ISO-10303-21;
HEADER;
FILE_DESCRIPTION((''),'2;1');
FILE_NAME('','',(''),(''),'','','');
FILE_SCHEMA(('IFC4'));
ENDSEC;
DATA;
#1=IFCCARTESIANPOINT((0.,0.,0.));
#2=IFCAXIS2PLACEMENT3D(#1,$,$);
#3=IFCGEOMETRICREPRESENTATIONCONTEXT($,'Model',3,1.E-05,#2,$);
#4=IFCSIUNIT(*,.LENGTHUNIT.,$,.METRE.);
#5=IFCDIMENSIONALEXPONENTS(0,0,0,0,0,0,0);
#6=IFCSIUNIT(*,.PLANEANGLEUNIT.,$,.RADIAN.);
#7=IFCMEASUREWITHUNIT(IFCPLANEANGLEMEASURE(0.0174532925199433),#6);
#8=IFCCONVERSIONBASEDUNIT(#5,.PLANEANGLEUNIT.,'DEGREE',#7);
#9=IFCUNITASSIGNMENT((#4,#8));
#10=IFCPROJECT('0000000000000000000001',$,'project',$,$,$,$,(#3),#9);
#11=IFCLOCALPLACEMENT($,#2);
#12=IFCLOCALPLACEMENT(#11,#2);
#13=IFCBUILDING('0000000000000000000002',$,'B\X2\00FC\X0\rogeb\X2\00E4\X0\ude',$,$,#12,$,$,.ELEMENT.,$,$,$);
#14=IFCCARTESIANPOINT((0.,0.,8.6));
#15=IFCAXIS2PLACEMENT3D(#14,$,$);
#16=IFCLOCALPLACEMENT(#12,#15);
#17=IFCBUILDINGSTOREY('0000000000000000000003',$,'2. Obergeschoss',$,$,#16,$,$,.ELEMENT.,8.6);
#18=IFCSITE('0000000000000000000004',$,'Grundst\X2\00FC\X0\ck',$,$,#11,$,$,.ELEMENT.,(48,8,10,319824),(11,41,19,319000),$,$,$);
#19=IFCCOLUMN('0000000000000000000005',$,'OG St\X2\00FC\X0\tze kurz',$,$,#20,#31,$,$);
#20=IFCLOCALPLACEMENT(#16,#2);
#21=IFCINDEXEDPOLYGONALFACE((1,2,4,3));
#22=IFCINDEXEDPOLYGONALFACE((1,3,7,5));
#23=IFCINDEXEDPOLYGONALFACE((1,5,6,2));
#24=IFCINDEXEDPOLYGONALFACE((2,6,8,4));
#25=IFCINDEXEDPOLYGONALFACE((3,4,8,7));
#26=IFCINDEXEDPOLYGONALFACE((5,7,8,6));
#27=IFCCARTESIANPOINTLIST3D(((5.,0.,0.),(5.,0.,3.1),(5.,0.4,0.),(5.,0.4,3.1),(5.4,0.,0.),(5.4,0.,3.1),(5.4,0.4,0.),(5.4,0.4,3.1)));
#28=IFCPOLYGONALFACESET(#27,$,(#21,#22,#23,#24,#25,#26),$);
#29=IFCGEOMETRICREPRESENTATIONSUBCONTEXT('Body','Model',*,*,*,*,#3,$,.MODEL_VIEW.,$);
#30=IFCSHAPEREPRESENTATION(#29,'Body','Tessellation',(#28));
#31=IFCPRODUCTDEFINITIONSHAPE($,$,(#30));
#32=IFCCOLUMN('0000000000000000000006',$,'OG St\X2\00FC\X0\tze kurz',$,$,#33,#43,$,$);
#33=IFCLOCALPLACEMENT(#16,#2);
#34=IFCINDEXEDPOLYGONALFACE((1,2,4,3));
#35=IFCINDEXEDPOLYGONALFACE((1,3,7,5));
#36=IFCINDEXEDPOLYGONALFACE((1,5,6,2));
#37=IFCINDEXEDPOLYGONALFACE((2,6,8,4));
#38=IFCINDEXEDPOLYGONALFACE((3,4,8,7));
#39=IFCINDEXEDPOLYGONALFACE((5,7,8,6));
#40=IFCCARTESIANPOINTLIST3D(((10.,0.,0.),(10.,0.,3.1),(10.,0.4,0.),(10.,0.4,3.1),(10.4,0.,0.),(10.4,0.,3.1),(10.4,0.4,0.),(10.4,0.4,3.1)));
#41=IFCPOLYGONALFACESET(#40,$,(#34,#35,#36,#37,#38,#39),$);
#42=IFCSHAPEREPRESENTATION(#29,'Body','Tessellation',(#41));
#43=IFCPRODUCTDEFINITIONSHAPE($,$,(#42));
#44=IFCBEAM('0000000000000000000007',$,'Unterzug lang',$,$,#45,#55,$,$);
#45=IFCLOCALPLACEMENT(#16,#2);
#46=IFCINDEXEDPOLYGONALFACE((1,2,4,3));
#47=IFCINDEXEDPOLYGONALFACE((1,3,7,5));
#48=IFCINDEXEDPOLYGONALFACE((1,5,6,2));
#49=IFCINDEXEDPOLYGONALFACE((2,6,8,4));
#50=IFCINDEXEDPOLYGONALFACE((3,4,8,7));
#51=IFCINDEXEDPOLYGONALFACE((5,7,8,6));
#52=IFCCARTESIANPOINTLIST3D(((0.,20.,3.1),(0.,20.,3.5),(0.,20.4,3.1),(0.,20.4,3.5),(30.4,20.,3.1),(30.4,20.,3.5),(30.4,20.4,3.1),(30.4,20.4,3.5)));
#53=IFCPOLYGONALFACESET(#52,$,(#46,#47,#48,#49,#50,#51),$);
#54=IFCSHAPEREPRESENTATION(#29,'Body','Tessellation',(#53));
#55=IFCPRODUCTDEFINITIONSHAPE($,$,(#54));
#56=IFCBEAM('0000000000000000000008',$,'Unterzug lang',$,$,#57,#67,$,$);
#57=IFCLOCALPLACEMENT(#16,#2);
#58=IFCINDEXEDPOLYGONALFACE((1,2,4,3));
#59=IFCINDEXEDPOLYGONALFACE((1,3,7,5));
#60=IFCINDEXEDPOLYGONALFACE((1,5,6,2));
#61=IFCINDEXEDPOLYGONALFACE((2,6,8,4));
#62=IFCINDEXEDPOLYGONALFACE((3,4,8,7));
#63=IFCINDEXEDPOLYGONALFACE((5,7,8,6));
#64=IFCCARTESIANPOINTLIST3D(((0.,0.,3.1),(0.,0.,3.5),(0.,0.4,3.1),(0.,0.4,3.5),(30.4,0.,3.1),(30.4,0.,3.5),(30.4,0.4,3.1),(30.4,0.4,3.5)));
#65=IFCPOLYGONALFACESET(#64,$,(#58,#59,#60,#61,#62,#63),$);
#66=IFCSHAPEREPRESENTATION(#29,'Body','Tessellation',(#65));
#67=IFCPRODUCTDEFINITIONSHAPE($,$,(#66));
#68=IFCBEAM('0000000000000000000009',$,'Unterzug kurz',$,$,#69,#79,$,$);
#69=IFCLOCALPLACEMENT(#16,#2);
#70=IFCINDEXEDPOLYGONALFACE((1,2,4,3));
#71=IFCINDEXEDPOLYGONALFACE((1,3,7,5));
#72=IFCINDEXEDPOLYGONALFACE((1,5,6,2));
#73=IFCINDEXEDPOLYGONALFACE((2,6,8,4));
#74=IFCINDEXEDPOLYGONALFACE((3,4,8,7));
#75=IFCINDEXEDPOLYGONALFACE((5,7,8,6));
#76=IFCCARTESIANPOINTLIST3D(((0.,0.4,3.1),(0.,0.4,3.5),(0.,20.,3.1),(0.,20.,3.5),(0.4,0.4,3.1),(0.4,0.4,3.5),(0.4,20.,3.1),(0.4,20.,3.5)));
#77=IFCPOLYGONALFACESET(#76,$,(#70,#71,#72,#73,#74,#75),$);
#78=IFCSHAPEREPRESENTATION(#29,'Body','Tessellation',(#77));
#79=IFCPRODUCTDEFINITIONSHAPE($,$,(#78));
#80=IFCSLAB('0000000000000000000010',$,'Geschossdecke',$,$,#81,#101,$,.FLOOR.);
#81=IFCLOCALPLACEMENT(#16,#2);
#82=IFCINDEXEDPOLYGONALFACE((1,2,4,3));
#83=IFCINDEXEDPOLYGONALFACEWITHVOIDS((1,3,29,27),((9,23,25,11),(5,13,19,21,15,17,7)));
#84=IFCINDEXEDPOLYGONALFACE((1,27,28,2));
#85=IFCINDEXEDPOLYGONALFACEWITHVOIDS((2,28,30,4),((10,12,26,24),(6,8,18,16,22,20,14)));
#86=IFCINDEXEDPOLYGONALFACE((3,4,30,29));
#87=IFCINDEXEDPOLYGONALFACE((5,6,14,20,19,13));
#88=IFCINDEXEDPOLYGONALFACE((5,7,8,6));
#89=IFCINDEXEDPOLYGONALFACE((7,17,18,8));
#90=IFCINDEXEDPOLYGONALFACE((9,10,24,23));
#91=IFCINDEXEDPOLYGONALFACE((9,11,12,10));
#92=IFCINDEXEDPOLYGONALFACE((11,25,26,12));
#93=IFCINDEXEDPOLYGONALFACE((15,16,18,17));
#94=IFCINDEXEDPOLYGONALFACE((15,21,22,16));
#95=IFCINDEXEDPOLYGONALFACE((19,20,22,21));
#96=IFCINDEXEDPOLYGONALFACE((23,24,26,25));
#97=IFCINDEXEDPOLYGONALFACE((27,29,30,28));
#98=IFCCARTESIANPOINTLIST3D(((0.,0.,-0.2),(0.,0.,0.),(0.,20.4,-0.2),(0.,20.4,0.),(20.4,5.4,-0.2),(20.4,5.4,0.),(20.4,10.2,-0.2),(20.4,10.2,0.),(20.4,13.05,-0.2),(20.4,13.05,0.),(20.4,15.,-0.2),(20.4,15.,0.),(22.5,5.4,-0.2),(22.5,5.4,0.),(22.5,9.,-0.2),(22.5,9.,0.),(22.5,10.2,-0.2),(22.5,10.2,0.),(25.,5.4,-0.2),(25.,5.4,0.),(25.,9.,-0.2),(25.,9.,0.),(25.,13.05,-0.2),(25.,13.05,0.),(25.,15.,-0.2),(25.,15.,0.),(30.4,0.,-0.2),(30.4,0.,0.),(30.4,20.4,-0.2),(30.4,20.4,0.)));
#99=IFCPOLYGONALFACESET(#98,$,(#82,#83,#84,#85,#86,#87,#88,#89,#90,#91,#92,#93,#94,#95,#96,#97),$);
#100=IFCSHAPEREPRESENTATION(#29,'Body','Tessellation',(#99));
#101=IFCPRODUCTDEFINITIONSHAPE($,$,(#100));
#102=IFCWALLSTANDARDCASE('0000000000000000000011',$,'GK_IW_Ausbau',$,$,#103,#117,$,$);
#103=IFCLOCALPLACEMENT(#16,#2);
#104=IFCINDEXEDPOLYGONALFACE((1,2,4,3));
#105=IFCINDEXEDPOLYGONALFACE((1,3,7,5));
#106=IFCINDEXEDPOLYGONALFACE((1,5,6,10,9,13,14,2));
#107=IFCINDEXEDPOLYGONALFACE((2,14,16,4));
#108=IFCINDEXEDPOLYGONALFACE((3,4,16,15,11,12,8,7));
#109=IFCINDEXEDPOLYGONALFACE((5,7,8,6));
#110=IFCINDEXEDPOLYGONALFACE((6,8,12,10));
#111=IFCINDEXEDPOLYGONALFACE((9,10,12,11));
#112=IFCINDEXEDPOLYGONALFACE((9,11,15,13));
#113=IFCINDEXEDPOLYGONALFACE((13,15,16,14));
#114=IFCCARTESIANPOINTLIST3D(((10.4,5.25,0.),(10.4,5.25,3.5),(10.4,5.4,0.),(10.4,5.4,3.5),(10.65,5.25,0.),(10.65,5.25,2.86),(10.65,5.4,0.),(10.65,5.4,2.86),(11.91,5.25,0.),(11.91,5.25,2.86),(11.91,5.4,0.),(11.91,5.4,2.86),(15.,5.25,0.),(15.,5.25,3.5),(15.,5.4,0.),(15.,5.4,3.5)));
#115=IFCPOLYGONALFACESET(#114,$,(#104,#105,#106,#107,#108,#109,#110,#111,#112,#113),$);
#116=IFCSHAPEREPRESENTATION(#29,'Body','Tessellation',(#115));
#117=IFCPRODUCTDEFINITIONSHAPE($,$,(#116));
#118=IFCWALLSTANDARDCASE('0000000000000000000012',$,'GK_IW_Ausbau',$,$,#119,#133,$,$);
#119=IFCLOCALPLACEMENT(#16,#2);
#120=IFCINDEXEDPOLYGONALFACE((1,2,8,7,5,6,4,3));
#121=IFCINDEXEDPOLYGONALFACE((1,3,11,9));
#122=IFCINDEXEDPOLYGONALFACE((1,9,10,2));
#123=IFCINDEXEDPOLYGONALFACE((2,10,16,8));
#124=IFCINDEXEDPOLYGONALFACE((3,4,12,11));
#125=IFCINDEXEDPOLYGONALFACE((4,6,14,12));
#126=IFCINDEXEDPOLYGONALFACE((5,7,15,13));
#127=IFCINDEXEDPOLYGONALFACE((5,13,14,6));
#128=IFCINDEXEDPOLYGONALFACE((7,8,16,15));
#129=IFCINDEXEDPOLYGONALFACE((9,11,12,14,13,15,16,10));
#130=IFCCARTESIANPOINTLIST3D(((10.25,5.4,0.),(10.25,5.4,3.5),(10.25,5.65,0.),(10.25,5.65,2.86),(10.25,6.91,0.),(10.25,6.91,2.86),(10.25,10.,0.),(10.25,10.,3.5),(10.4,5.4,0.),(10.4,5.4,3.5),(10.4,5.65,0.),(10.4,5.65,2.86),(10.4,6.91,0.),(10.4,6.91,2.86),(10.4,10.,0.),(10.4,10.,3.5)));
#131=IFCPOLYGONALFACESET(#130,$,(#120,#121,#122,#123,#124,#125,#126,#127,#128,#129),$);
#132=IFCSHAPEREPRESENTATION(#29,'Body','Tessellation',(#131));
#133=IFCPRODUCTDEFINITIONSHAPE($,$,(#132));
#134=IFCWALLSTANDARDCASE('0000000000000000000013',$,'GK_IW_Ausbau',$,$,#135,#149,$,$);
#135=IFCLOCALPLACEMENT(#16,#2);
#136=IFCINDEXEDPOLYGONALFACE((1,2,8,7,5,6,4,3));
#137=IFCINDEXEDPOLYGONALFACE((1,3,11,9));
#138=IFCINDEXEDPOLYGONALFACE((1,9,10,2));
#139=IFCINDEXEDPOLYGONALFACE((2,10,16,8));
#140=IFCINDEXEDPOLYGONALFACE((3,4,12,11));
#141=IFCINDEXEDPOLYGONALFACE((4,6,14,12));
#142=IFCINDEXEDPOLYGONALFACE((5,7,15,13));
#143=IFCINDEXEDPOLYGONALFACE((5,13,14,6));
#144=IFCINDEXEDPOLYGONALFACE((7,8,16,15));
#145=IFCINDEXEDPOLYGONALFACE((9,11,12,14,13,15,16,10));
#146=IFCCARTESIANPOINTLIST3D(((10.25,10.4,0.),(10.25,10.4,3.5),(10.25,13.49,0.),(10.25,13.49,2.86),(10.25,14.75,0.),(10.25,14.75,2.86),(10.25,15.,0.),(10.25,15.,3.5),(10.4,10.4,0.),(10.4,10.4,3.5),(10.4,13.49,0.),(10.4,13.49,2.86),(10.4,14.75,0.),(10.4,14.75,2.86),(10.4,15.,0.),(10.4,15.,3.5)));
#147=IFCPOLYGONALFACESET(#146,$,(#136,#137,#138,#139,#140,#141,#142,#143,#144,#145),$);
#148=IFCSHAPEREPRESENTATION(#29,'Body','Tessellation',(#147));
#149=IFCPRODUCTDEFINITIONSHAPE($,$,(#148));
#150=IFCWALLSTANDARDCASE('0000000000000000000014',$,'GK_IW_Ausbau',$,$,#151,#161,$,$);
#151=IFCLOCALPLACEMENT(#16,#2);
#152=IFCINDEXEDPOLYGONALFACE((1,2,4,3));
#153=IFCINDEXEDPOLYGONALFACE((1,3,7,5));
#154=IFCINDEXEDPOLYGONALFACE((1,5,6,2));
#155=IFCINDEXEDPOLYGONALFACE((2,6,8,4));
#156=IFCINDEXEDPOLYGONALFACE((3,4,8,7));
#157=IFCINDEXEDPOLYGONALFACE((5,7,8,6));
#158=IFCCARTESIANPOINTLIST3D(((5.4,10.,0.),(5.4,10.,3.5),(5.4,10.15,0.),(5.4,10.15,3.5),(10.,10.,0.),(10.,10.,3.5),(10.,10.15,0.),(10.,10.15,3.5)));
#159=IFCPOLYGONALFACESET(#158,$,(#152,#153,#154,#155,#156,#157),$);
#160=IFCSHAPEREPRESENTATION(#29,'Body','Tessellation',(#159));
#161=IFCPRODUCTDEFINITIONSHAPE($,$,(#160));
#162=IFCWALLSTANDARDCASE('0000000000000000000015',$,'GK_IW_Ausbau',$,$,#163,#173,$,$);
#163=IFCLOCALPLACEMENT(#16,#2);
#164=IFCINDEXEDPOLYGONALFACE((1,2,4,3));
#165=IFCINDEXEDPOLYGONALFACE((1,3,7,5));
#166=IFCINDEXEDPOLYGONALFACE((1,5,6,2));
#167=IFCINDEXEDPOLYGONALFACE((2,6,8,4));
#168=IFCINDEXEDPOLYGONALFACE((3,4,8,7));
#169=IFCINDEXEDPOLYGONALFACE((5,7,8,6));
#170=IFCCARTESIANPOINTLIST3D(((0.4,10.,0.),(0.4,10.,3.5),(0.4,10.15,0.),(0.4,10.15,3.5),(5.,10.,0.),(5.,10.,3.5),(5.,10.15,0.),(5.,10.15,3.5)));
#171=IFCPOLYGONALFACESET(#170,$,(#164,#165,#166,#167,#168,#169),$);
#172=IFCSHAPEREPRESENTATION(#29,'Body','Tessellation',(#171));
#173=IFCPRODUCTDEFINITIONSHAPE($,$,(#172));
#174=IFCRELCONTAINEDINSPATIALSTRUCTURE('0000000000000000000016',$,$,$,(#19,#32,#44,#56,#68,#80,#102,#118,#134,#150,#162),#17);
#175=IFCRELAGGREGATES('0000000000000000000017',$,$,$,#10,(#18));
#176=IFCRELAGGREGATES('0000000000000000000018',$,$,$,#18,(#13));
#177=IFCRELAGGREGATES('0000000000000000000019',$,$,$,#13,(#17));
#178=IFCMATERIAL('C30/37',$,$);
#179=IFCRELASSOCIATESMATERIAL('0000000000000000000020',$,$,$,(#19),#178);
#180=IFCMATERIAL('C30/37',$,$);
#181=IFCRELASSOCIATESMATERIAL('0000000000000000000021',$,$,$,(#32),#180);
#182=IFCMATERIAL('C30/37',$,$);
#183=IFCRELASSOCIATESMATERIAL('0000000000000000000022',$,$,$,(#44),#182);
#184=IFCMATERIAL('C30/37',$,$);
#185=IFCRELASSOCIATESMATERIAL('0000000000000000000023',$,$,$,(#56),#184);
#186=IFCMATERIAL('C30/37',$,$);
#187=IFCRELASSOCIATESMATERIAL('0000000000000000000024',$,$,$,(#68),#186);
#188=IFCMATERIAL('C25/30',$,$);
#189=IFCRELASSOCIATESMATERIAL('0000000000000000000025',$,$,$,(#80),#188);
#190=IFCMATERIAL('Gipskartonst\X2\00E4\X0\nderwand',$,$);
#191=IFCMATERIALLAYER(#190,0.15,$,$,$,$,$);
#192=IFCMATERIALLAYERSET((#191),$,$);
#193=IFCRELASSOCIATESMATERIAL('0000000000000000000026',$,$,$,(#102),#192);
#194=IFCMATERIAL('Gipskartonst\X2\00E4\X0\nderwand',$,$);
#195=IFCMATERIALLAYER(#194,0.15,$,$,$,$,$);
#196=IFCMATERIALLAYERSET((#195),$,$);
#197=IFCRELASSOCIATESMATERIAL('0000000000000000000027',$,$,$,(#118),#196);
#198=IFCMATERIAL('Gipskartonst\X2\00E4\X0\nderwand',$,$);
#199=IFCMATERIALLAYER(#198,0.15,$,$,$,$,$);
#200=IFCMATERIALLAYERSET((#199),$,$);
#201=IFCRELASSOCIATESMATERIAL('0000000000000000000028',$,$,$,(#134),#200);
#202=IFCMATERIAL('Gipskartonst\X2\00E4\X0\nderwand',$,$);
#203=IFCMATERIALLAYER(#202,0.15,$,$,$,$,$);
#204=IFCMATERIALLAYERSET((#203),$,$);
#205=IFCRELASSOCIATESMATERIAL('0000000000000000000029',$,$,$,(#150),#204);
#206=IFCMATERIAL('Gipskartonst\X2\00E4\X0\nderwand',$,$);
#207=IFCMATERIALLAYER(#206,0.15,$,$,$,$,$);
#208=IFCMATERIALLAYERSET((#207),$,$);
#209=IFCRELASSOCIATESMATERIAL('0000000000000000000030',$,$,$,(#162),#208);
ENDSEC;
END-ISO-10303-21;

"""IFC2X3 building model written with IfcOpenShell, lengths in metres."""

from ifc_helpers import new_model, entity, si_unit, converted_unit, frame, frame_2d, origin, origin_with_axes, place, context, subcontext, project, spatial, polyline, rectangle, outline, extrude, material, layer, layer_set, layer_usage, element, save


model = new_model("IFC2X3")

# Units and contexts
model_context = context("Model", 3, precision=1e-05, world=origin())
body_context = subcontext(model_context, "Body", "Model", "MODEL_VIEW")
ifc_project = project(units=[si_unit("LENGTHUNIT", "METRE"), converted_unit("PLANEANGLEUNIT", "DEGREE", entity("IfcPlaneAngleMeasure", 0.0174532925199433), si_unit("PLANEANGLEUNIT", "RADIAN"), dimensions=[0, 0, 0, 0, 0, 0, 0])], contexts=[model_context])

# Site, building, storey
site_placement = place(None, origin())
site = spatial("IfcSite", under=ifc_project, at=site_placement, Name="Grundstück", CompositionType="ELEMENT", RefLatitude=(48, 8, 10, 319824), RefLongitude=(11, 41, 19, 319000))
building_placement = place(site_placement, origin())
building = spatial("IfcBuilding", under=site, at=building_placement, Name="Bürogebäude", CompositionType="ELEMENT")
storey_placement = place(building_placement, frame((0.0, 0.0, 8.6)))
storey = spatial("IfcBuildingStorey", under=building, at=storey_placement, Name="2. Obergeschoss", CompositionType="ELEMENT", Elevation=8.6)

# Columns
ifc_material_1 = material(Name="C30/37")
column_1_placement = place(storey_placement, frame((5.0, 0.0, 0.0)))
element("IfcColumn", 1, at=column_1_placement, inside=storey, material=ifc_material_1, Name="OG Stütze kurz", context=body_context, shape_type="SweptSolid", body=[
    extrude(rectangle(XDim=0.4, YDim=0.4, at=frame_2d((0.2, 0.2), x_axis=(1.0, 0.0))), origin_with_axes(), (0.0, 0.0, 1.0), 3.1),
])
ifc_material_2 = material(Name="C30/37")
column_2_placement = place(storey_placement, frame((10.0, 0.0, 0.0)))
element("IfcColumn", 2, at=column_2_placement, inside=storey, material=ifc_material_2, Name="OG Stütze kurz", context=body_context, shape_type="SweptSolid", body=[
    extrude(rectangle(XDim=0.4, YDim=0.4, at=frame_2d((0.2, 0.2), x_axis=(1.0, 0.0))), origin_with_axes(), (0.0, 0.0, 1.0), 3.1),
])

# Beams
ifc_material_3 = material(Name="C30/37")
beam_1_placement = place(storey_placement, frame((0.0, 20.0, 3.1)))
element("IfcBeam", 3, at=beam_1_placement, inside=storey, material=ifc_material_3, Name="Unterzug lang", context=body_context, shape_type="SweptSolid", body=[
    extrude(rectangle(XDim=0.4, YDim=0.4, at=frame_2d((0.2, 0.2), x_axis=(1.0, 0.0))), frame((0.0, 0.0, 0.0), z_axis=(1.0, 0.0, 0.0), x_axis=(0.0, 1.0, 0.0)), (0.0, 0.0, 1.0), 30.4),
])
ifc_material_4 = material(Name="C30/37")
beam_2_placement = place(storey_placement, frame((0.0, 0.0, 3.1), z_axis=(0.0, 0.0, 1.0), x_axis=(1.0, 0.0, 0.0)))
element("IfcBeam", 4, at=beam_2_placement, inside=storey, material=ifc_material_4, Name="Unterzug lang", context=body_context, shape_type="SweptSolid", body=[
    extrude(rectangle(XDim=0.4, YDim=0.4, at=frame_2d((0.2, 0.2), x_axis=(1.0, 0.0))), frame((0.0, 0.0, 0.0), z_axis=(1.0, 0.0, 0.0), x_axis=(0.0, 1.0, 0.0)), (0.0, 0.0, 1.0), 30.4),
])
ifc_material_5 = material(Name="C30/37")
beam_3_placement = place(storey_placement, frame((0.0, 20.0, 3.1), z_axis=(0.0, 0.0, 1.0), x_axis=(0.0, -1.0, 0.0)))
element("IfcBeam", 5, at=beam_3_placement, inside=storey, material=ifc_material_5, Name="Unterzug kurz", context=body_context, shape_type="SweptSolid", body=[
    extrude(rectangle(XDim=0.4, YDim=0.4, at=frame_2d((0.2, 0.2), x_axis=(1.0, 0.0))), frame((0.0, 0.0, 0.0), z_axis=(1.0, 0.0, 0.0), x_axis=(0.0, 1.0, 0.0)), (0.0, 0.0, 1.0), 19.6),
])

# Slab, openings
ifc_material_6 = material(Name="C25/30")
slab_placement = place(storey_placement, frame((0.0, 0.0, -0.2)))
slab = element("IfcSlab", 6, at=slab_placement, inside=storey, material=ifc_material_6, Name="Geschossdecke", PredefinedType="FLOOR", context=body_context, shape_type="SweptSolid", body=[
    extrude(rectangle(XDim=30.4, YDim=20.4, at=frame_2d((15.2, 10.2), x_axis=(1.0, 0.0))), origin_with_axes(), (0.0, 0.0, 1.0), 0.2),
])
opening_1_placement = place(slab_placement, frame((22.5, 5.4, 0.0)))
element("IfcOpeningElement", 7, at=opening_1_placement, cuts=slab, ObjectType="Opening", context=body_context, shape_type="SweptSolid", body=[
    extrude(rectangle(XDim=3.6, YDim=2.5, at=frame_2d((0.0, 0.0), x_axis=(0.0, -1.0))), frame((1.25, 1.8, 0.0), z_axis=(0.0, 0.0, 1.0), x_axis=(1.0, 0.0, 0.0)), (0.0, 0.0, 1.0), 0.2),
])
opening_2_placement = place(slab_placement, frame((20.4, 5.4, 0.0)))
element("IfcOpeningElement", 8, at=opening_2_placement, cuts=slab, ObjectType="Opening", context=body_context, shape_type="SweptSolid", body=[
    extrude(rectangle(XDim=2.1, YDim=4.8, at=frame_2d((0.0, 0.0), x_axis=(-1.0, 0.0))), frame((1.05, 2.4, 0.0), z_axis=(0.0, 0.0, 1.0), x_axis=(1.0, 0.0, 0.0)), (0.0, 0.0, 1.0), 0.2),
])
opening_3_placement = place(slab_placement, frame((20.4, 13.05, 0.0)))
element("IfcOpeningElement", 9, at=opening_3_placement, cuts=slab, ObjectType="Opening", context=body_context, shape_type="SweptSolid", body=[
    extrude(rectangle(XDim=1.95, YDim=4.6, at=frame_2d((0.0, 0.0), x_axis=(0.0, -1.0))), frame((2.3, 0.975, 0.0), z_axis=(0.0, 0.0, 1.0), x_axis=(1.0, 0.0, 0.0)), (0.0, 0.0, 1.0), 0.2),
])

# Walls, openings
ifc_material_7 = material(Name="Gipskartonständerwand")
ifc_layer_1 = layer(ifc_material_7, 0.15)
ifc_layer_set_1 = layer_set([ifc_layer_1])
ifc_layer_usage_1 = layer_usage(ifc_layer_set_1, "AXIS2", "POSITIVE", -0.15)
wall_1_placement = place(storey_placement, frame((10.4, 5.25, 0.0)))
wall_1 = element("IfcWallStandardCase", 10, at=wall_1_placement, inside=storey, material=ifc_layer_usage_1, Name="GK_IW_Ausbau", context=body_context, shape_type="SweptSolid", body=[
    extrude(rectangle(XDim=4.6, YDim=0.15, at=frame_2d((2.3, 0.075), x_axis=(1.0, 0.0))), origin_with_axes(), (0.0, 0.0, 1.0), 3.5),
])
opening_4_placement = place(wall_1_placement, frame((1.51, 0.15, 0.0), z_axis=(0.0, -1.0, 0.0), x_axis=(0.0, 0.0, 1.0)))
element("IfcOpeningElement", 11, at=opening_4_placement, cuts=wall_1, ObjectType="Opening", context=body_context, shape_type="SweptSolid", body=[
    extrude(outline(polyline([(0.0, 1.26), (2.86, 1.26), (2.86, 0.0), (0.0, 0.0), (0.0, 1.26)])), origin_with_axes(), (0.0, 0.0, 1.0), 0.15),
])
ifc_material_8 = material(Name="Gipskartonständerwand")
ifc_layer_2 = layer(ifc_material_8, 0.15)
ifc_layer_set_2 = layer_set([ifc_layer_2])
ifc_layer_usage_2 = layer_usage(ifc_layer_set_2, "AXIS2", "POSITIVE", -0.15)
wall_2_placement = place(storey_placement, frame((10.25, 10.0, 0.0), z_axis=(0.0, 0.0, 1.0), x_axis=(0.0, -1.0, 0.0)))
wall_2 = element("IfcWallStandardCase", 12, at=wall_2_placement, inside=storey, material=ifc_layer_usage_2, Name="GK_IW_Ausbau", context=body_context, shape_type="SweptSolid", body=[
    extrude(rectangle(XDim=4.6, YDim=0.15, at=frame_2d((2.3, 0.075), x_axis=(1.0, 0.0))), origin_with_axes(), (0.0, 0.0, 1.0), 3.5),
])
opening_5_placement = place(wall_2_placement, frame((4.35, 0.15, 0.0), z_axis=(0.0, -1.0, 0.0), x_axis=(0.0, 0.0, 1.0)))
element("IfcOpeningElement", 13, at=opening_5_placement, cuts=wall_2, ObjectType="Opening", context=body_context, shape_type="SweptSolid", body=[
    extrude(outline(polyline([(0.0, 1.26), (2.86, 1.26), (2.86, 0.0), (0.0, 0.0), (0.0, 1.26)])), origin_with_axes(), (0.0, 0.0, 1.0), 0.15),
])
ifc_material_9 = material(Name="Gipskartonständerwand")
ifc_layer_3 = layer(ifc_material_9, 0.15)
ifc_layer_set_3 = layer_set([ifc_layer_3])
ifc_layer_usage_3 = layer_usage(ifc_layer_set_3, "AXIS2", "POSITIVE", -0.15)
wall_3_placement = place(storey_placement, frame((10.25, 15.0, 0.0), z_axis=(0.0, 0.0, 1.0), x_axis=(0.0, -1.0, 0.0)))
wall_3 = element("IfcWallStandardCase", 14, at=wall_3_placement, inside=storey, material=ifc_layer_usage_3, Name="GK_IW_Ausbau", context=body_context, shape_type="SweptSolid", body=[
    extrude(rectangle(XDim=4.6, YDim=0.15, at=frame_2d((2.3, 0.075), x_axis=(1.0, 0.0))), origin_with_axes(), (0.0, 0.0, 1.0), 3.5),
])
opening_6_placement = place(wall_3_placement, frame((1.51, 0.15, 0.0), z_axis=(0.0, -1.0, 0.0), x_axis=(0.0, 0.0, 1.0)))
element("IfcOpeningElement", 15, at=opening_6_placement, cuts=wall_3, ObjectType="Opening", context=body_context, shape_type="SweptSolid", body=[
    extrude(outline(polyline([(0.0, 1.26), (2.86, 1.26), (2.86, 0.0), (0.0, 0.0), (0.0, 1.26)])), origin_with_axes(), (0.0, 0.0, 1.0), 0.15),
])

# Walls
ifc_material_10 = material(Name="Gipskartonständerwand")
ifc_layer_4 = layer(ifc_material_10, 0.15)
ifc_layer_set_4 = layer_set([ifc_layer_4])
ifc_layer_usage_4 = layer_usage(ifc_layer_set_4, "AXIS2", "POSITIVE", -0.15)
wall_4_placement = place(storey_placement, frame((10.0, 10.15, 0.0), z_axis=(0.0, 0.0, 1.0), x_axis=(-1.0, 0.0, 0.0)))
element("IfcWallStandardCase", 16, at=wall_4_placement, inside=storey, material=ifc_layer_usage_4, Name="GK_IW_Ausbau", context=body_context, shape_type="SweptSolid", body=[
    extrude(rectangle(XDim=4.6, YDim=0.15, at=frame_2d((2.3, 0.075), x_axis=(1.0, 0.0))), origin_with_axes(), (0.0, 0.0, 1.0), 3.5),
])
ifc_material_11 = material(Name="Gipskartonständerwand")
ifc_layer_5 = layer(ifc_material_11, 0.15)
ifc_layer_set_5 = layer_set([ifc_layer_5])
ifc_layer_usage_5 = layer_usage(ifc_layer_set_5, "AXIS2", "POSITIVE", -0.15)
wall_5_placement = place(storey_placement, frame((5.0, 10.15, 0.0), z_axis=(0.0, 0.0, 1.0), x_axis=(-1.0, 0.0, 0.0)))
element("IfcWallStandardCase", 17, at=wall_5_placement, inside=storey, material=ifc_layer_usage_5, Name="GK_IW_Ausbau", context=body_context, shape_type="SweptSolid", body=[
    extrude(rectangle(XDim=4.6, YDim=0.15, at=frame_2d((2.3, 0.075), x_axis=(1.0, 0.0))), origin_with_axes(), (0.0, 0.0, 1.0), 3.5),
])

save(model, "model.ifc")
